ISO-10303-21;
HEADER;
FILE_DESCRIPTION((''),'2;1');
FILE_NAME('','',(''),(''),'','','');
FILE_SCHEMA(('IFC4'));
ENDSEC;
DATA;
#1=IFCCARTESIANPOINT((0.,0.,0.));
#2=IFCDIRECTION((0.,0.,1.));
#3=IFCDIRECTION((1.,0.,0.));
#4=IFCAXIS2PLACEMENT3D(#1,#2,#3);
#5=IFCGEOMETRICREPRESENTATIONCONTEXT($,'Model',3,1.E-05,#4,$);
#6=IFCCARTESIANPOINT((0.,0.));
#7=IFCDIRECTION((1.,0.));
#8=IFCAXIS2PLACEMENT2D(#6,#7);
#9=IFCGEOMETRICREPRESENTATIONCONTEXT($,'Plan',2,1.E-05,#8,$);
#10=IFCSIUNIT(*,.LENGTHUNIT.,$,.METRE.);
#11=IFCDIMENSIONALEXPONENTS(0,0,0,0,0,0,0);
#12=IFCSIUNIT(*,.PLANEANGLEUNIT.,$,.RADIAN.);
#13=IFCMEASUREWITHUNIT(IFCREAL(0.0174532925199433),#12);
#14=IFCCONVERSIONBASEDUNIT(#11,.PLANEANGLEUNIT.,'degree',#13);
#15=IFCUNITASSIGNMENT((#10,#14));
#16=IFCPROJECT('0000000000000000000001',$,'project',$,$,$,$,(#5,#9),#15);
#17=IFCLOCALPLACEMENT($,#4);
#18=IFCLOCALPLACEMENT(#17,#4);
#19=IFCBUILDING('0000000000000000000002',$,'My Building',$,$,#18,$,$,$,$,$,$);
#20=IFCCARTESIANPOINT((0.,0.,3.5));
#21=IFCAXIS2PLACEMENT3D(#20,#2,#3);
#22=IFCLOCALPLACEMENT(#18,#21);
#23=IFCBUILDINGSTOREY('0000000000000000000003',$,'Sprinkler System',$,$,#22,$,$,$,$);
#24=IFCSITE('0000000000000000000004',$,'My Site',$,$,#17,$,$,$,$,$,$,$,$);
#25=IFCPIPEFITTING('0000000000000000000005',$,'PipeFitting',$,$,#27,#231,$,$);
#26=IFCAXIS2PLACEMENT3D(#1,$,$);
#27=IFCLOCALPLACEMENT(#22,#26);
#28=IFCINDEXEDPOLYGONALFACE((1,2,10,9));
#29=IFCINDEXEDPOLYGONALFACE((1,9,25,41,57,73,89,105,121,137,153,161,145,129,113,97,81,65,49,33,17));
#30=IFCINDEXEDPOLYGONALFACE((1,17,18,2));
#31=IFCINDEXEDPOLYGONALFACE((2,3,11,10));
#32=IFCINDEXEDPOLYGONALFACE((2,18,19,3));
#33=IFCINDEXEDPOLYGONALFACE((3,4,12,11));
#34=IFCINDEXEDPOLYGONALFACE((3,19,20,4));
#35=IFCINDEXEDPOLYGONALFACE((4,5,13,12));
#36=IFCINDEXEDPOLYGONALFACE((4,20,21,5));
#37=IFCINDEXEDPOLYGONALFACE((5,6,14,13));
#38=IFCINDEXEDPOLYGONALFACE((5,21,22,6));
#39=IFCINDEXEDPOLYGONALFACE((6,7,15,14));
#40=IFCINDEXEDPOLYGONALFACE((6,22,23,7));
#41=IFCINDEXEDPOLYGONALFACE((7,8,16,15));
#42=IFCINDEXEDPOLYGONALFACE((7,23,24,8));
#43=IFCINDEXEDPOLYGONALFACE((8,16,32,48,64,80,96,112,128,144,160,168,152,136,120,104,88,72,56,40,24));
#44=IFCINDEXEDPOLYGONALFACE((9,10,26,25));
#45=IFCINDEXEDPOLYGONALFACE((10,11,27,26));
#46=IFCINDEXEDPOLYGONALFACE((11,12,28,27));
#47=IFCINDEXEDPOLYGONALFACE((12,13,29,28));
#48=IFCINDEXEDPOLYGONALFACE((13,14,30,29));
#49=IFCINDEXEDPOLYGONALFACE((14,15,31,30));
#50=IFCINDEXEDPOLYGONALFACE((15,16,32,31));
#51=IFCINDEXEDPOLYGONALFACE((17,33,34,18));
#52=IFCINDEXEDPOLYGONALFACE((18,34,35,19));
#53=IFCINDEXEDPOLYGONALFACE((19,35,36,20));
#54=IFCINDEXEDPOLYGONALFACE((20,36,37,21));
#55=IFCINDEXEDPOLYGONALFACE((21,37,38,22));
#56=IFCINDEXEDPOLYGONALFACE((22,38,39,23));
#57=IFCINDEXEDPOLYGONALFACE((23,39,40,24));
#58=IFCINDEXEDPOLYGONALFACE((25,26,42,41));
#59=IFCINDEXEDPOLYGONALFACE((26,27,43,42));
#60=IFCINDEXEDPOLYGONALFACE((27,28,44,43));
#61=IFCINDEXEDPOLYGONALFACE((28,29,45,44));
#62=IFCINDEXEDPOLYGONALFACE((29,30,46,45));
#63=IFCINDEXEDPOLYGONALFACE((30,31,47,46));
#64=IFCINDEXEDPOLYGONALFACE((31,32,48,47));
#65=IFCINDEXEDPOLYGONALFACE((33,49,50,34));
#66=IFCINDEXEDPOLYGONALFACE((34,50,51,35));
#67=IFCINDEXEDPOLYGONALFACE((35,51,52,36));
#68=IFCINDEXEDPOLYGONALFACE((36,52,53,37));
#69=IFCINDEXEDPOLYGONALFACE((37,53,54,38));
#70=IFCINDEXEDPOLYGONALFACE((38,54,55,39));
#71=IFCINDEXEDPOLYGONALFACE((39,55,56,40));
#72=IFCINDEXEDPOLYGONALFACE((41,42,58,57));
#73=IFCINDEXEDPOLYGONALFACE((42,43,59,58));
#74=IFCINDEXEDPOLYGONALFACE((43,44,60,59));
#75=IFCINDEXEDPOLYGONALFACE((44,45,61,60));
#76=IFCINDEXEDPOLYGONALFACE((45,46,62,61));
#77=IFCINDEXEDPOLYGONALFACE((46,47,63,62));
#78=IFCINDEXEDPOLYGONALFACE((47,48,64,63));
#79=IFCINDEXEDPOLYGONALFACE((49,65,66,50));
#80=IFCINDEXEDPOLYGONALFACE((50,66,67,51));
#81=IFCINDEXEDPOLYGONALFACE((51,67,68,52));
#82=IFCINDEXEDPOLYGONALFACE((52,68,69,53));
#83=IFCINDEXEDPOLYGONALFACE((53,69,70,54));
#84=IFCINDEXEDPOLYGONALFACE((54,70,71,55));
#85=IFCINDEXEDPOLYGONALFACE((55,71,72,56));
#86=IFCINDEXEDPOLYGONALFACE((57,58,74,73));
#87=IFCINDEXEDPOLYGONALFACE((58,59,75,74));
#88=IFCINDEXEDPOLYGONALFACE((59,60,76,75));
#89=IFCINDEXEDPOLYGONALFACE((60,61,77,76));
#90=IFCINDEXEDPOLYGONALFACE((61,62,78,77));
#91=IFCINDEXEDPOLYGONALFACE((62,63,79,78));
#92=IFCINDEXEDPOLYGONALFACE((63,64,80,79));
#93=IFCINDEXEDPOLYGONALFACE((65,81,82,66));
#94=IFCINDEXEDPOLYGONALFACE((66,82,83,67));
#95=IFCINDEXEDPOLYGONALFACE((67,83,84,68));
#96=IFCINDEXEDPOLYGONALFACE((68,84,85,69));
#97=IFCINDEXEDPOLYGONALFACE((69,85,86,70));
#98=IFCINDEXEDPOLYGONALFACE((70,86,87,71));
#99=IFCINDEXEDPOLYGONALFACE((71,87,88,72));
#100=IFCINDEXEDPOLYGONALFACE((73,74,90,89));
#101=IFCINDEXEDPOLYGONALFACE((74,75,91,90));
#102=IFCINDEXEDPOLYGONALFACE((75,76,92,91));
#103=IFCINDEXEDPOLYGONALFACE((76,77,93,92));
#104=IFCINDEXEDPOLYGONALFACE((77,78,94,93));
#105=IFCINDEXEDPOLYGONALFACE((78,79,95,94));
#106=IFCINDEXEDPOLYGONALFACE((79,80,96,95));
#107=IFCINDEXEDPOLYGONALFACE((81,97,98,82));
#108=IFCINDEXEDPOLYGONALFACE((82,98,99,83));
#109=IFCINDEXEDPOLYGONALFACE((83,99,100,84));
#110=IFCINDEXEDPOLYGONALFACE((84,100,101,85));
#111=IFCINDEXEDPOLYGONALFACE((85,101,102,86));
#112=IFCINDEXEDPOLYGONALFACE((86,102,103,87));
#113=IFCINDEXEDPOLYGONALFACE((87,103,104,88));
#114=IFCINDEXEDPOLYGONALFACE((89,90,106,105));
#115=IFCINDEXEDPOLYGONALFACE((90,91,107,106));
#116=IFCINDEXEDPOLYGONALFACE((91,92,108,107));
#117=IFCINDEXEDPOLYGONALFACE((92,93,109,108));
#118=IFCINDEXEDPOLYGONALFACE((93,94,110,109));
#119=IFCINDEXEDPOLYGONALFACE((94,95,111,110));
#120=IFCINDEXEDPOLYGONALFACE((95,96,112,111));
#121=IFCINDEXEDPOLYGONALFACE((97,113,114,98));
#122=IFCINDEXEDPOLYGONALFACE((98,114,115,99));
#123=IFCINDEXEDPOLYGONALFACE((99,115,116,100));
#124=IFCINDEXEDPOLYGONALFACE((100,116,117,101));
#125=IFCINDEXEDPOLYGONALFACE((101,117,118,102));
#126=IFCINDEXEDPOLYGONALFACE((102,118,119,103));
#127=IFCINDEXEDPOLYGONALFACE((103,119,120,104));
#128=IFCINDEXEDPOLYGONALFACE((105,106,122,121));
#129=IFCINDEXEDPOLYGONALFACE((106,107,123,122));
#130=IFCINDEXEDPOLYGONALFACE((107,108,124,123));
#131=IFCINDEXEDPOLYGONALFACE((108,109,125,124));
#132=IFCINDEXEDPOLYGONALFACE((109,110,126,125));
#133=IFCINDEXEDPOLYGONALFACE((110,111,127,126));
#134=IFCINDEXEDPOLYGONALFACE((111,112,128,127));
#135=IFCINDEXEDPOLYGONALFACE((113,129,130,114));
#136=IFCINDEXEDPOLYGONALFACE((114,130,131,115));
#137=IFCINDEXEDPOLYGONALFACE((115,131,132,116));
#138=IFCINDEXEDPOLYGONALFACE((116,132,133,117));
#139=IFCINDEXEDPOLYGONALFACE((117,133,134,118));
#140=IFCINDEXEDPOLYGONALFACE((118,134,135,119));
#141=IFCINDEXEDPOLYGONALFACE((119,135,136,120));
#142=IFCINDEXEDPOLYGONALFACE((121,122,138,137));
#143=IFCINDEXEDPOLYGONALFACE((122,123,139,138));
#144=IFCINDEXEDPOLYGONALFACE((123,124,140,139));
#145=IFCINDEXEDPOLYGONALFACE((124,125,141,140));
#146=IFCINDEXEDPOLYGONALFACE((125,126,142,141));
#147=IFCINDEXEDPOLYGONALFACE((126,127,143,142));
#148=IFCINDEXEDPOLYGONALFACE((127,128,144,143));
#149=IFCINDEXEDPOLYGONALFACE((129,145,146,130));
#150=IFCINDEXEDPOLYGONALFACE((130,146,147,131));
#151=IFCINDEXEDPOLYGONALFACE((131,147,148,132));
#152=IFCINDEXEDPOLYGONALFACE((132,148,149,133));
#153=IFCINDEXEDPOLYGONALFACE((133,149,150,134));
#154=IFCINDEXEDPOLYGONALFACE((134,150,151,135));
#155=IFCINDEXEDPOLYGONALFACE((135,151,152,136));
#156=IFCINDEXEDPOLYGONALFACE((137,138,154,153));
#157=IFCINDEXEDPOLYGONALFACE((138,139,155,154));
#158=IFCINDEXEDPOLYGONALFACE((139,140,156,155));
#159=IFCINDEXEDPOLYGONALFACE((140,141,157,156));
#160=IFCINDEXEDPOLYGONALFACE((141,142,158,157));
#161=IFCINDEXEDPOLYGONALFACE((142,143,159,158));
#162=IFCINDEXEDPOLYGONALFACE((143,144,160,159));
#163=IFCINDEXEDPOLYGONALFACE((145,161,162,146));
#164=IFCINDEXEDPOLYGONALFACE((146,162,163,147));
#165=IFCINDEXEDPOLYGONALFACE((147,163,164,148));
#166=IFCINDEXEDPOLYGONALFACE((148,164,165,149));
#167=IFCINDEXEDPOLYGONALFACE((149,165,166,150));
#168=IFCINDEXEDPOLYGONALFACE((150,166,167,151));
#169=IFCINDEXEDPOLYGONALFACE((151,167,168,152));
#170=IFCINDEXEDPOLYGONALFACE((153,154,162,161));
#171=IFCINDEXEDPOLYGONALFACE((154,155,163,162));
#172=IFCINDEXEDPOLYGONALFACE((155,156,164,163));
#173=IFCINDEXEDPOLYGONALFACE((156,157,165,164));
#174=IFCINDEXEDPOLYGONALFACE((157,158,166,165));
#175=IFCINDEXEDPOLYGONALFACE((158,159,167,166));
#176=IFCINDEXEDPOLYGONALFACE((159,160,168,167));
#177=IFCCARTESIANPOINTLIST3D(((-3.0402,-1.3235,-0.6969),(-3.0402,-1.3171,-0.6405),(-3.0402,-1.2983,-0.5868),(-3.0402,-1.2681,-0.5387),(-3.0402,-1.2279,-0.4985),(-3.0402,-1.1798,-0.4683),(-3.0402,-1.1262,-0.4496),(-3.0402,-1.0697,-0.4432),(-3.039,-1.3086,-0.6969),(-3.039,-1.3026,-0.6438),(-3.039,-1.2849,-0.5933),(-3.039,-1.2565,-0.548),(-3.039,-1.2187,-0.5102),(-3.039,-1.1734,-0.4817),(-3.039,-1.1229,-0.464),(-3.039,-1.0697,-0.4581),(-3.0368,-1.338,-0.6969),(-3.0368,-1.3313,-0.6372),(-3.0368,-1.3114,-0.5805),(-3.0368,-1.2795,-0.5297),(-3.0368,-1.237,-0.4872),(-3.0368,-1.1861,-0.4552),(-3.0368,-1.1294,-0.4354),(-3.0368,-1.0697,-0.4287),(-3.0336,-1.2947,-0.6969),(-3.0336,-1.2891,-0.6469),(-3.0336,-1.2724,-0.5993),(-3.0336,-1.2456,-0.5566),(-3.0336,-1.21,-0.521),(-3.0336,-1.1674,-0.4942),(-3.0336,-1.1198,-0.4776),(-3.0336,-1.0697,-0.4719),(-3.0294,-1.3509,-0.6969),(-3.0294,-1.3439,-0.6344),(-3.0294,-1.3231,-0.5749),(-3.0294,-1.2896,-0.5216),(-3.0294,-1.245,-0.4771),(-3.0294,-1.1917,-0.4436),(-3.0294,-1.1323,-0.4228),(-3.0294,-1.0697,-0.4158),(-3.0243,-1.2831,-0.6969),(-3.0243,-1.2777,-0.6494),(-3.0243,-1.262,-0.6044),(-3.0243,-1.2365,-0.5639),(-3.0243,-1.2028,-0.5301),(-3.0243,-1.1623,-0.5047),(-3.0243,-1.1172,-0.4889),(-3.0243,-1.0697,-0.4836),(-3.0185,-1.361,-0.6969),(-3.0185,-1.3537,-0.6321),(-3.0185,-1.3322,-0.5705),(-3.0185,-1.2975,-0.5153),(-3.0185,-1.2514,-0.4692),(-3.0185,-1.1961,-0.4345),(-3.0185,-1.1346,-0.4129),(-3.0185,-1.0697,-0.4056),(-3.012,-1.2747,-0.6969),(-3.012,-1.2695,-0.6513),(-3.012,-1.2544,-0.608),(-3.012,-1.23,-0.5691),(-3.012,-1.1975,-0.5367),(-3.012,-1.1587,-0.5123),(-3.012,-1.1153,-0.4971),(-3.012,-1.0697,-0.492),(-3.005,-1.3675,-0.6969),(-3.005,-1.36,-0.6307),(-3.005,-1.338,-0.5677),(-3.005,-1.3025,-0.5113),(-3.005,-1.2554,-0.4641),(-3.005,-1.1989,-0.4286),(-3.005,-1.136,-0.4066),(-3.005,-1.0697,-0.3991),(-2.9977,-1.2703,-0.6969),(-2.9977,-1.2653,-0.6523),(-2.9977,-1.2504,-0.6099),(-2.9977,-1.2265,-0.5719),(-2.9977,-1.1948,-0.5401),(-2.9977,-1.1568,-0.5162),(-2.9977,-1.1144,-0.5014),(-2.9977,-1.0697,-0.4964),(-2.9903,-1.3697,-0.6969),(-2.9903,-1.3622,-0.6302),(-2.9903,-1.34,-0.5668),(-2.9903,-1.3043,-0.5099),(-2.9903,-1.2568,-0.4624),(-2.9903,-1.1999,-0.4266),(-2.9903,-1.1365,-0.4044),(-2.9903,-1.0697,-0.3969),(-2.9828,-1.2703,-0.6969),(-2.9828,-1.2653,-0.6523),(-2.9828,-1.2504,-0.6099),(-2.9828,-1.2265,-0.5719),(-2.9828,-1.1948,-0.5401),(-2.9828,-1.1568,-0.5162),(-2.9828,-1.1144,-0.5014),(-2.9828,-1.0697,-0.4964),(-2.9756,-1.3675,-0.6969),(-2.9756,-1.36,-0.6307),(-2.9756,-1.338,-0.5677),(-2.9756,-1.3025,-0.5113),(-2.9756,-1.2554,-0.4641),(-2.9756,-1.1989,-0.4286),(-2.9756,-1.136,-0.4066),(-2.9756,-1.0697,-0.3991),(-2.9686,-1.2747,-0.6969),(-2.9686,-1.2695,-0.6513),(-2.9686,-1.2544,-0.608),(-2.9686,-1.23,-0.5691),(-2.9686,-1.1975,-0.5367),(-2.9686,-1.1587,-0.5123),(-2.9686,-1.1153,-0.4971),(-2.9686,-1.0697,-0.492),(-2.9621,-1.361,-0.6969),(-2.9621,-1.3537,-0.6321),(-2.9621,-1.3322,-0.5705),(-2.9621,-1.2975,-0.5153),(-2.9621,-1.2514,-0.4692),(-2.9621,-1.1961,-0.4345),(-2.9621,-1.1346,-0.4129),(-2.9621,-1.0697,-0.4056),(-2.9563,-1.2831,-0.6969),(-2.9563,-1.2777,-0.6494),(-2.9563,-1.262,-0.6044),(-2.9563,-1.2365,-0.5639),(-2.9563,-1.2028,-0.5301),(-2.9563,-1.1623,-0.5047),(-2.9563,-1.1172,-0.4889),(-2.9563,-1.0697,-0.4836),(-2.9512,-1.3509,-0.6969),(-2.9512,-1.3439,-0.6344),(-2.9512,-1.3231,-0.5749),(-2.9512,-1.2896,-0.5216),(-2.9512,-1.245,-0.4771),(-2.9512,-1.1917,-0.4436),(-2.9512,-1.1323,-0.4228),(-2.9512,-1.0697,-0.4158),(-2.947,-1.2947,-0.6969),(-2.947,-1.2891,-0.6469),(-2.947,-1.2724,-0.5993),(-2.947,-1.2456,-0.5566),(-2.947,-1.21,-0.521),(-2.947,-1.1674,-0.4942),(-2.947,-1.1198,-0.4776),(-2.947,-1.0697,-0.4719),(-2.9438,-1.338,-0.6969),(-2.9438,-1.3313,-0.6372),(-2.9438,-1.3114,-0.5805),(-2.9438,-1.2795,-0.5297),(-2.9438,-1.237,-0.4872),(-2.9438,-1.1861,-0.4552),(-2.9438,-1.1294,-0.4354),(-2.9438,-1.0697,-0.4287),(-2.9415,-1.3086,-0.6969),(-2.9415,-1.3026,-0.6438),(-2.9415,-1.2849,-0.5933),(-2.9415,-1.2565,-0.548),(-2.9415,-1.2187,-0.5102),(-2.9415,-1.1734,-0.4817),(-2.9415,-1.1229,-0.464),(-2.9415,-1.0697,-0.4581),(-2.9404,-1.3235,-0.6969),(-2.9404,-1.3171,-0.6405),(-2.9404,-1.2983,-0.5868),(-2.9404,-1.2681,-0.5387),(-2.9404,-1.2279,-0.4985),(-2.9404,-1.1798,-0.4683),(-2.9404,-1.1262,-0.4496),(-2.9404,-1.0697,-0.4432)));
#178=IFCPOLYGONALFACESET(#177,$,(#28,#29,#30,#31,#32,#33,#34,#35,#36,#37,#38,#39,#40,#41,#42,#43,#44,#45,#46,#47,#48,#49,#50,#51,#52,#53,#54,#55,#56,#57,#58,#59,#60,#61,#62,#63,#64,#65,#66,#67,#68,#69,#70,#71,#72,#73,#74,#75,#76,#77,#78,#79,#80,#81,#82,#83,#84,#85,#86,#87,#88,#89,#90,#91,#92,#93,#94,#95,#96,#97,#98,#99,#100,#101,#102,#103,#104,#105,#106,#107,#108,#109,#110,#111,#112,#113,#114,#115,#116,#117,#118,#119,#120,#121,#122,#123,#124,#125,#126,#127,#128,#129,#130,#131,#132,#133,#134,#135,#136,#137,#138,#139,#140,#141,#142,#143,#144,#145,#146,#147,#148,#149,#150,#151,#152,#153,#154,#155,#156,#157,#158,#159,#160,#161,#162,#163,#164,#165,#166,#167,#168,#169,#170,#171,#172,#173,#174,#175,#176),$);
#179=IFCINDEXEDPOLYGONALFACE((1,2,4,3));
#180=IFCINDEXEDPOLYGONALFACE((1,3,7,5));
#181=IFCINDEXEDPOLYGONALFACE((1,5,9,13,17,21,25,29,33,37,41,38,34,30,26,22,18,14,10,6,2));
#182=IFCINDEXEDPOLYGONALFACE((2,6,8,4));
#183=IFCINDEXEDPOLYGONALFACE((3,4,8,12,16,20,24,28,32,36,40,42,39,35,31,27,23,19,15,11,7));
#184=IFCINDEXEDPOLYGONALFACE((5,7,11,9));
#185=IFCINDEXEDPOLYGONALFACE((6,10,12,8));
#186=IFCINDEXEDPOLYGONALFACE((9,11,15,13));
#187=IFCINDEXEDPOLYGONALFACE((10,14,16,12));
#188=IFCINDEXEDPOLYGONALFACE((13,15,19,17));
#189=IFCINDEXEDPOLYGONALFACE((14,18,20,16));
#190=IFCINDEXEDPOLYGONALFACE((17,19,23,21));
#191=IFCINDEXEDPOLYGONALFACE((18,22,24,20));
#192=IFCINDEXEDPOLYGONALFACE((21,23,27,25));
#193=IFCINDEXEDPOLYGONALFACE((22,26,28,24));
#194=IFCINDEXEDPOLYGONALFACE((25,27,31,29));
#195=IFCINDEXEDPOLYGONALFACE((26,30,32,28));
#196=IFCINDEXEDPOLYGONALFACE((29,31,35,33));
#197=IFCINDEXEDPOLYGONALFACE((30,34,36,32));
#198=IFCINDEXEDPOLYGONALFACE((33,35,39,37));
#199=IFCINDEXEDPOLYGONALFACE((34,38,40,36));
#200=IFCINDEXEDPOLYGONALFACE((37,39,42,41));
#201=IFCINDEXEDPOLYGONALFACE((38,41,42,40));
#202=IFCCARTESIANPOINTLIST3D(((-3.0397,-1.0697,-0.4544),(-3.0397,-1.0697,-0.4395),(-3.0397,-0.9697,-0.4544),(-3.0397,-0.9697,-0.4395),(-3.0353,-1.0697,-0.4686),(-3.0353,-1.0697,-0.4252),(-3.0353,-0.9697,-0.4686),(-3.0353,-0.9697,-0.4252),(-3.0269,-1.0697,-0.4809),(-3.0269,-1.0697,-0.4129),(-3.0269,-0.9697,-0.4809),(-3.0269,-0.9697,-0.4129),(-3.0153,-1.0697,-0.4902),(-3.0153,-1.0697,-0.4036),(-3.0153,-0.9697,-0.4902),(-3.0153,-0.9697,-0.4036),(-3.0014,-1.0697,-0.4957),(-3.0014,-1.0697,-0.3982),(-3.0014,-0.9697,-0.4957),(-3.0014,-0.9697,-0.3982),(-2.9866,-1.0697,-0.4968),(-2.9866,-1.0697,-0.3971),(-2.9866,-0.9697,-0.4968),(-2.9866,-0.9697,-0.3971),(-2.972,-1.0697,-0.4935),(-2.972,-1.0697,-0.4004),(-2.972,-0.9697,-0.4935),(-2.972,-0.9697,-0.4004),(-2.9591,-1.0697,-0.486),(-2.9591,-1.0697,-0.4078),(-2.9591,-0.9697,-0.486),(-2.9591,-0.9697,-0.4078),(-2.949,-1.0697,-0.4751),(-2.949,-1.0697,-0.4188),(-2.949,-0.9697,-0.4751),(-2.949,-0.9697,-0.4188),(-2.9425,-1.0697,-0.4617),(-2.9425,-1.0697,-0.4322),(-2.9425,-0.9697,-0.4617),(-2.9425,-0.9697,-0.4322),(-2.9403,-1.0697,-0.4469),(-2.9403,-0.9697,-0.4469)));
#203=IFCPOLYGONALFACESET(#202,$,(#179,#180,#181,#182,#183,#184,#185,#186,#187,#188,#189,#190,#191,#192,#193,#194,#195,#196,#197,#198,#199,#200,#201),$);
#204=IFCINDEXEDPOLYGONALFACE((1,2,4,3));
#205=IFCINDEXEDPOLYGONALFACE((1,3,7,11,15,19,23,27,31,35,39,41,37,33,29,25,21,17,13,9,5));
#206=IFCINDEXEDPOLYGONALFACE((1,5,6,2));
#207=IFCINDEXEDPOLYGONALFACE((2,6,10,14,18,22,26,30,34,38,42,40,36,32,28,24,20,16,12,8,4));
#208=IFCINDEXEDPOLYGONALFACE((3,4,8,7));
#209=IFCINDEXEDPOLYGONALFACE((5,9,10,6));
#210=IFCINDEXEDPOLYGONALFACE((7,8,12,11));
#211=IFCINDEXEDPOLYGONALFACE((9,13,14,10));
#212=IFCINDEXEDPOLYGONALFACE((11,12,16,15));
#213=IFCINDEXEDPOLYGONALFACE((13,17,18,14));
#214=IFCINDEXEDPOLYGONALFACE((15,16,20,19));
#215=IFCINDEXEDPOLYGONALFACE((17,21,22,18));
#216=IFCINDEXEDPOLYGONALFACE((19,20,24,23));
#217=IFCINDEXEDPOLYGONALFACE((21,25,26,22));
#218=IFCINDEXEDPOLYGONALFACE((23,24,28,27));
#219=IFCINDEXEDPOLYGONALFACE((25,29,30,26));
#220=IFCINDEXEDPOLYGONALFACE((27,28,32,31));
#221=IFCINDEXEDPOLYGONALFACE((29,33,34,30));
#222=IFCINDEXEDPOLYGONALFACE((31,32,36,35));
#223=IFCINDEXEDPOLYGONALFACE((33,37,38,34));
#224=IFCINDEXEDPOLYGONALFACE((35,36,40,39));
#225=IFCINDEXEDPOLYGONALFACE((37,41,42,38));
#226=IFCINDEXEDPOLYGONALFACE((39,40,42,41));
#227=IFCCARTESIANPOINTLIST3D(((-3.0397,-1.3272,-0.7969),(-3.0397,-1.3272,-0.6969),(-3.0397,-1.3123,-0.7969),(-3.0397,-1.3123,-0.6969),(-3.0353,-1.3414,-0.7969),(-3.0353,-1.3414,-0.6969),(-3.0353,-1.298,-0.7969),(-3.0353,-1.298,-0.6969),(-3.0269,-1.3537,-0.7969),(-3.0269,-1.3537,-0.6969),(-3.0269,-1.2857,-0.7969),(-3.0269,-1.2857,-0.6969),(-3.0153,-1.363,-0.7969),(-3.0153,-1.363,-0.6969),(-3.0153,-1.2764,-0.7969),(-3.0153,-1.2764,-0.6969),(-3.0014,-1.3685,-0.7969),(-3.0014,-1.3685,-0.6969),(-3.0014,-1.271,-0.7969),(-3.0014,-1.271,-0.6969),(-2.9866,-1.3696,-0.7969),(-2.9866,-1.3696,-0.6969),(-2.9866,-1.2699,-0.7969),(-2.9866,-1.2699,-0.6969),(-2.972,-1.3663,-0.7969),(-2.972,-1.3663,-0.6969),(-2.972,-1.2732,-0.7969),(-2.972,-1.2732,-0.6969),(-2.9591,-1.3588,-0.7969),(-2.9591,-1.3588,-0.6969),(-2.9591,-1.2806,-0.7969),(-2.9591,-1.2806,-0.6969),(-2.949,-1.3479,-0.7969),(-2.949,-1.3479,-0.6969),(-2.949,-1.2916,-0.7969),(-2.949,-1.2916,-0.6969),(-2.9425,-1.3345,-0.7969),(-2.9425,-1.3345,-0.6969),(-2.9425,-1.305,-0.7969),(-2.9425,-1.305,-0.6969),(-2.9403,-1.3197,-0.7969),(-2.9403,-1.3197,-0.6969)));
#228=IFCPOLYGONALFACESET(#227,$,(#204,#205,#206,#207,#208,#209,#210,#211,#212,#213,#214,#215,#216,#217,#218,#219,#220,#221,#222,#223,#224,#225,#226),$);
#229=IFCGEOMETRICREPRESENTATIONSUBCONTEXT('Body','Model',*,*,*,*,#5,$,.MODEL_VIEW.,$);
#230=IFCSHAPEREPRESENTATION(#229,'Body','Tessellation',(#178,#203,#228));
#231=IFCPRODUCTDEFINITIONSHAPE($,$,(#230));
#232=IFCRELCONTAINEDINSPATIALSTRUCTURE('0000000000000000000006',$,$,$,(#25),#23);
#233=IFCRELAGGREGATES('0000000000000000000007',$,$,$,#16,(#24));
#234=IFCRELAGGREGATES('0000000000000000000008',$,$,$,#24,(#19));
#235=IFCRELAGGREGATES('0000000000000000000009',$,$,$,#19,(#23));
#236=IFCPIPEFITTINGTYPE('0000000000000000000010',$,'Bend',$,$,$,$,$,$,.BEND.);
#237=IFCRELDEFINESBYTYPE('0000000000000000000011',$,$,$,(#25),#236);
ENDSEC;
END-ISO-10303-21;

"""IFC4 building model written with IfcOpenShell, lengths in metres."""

from ifc_helpers import new_model, entity, si_unit, converted_unit, frame, origin_with_axes, origin_2d_with_axis, place, context, subcontext, project, spatial, circle, extrude, source, transform, mapped, type_object, type_shapes, element, save


model = new_model("IFC4")

# Units and contexts
model_context = context("Model", 3, precision=1e-05, world=origin_with_axes())
plan_context = context("Plan", 2, precision=1e-05, world=origin_2d_with_axis())
body_context = subcontext(model_context, "Body", "Model", "MODEL_VIEW")
ifc_project = project(units=[si_unit("LENGTHUNIT", "METRE"), converted_unit("PLANEANGLEUNIT", "degree", entity("IfcReal", 0.0174532925199433), si_unit("PLANEANGLEUNIT", "RADIAN"), dimensions=[0, 0, 0, 0, 0, 0, 0])], contexts=[model_context, plan_context])

# Site, building, storey
site_placement = place(None, origin_with_axes())
site = spatial("IfcSite", under=ifc_project, at=site_placement, Name="My Site")
building_placement = place(site_placement, origin_with_axes())
building = spatial("IfcBuilding", under=site, at=building_placement, Name="My Building")
storey_placement = place(building_placement, frame((0.0, 0.0, 3.5), z_axis=(0.0, 0.0, 1.0), x_axis=(1.0, 0.0, 0.0)))
storey = spatial("IfcBuildingStorey", under=building, at=storey_placement, Name="Sprinkler System")

# Pipe fitting
pipe_fitting_type_1 = type_object("IfcPipeFittingType", Name="Bend", PredefinedType="BEND")
shared_shape_1 = source(origin_with_axes(), body_context, "Body", "SolidModel", [
    entity("IfcSweptDiskSolid", entity("IfcIndexedPolyCurve", entity("IfcCartesianPointList3D", [[0.0, 0.0, 0.1], [0.0, -0.0732, 0.2768], [0.0, -0.25, 0.35]]), [entity("IfcArcIndex", [1, 2, 3])]), 0.05),
    extrude(circle(Radius=0.05), origin_with_axes(), (0.0, 0.0, 1.0), 0.1),
    extrude(circle(Radius=0.05), frame((0.0, -0.25, 0.35), z_axis=(0.0, -1.0, 0.000044), x_axis=(1.0, 0.0, 0.0)), (0.0, 0.0, 1.0), 0.1),
])
type_shapes(pipe_fitting_type_1, [shared_shape_1])
for number, where, z_axis, x_axis, name in (
    (1, (-2.9903, -0.9697, -0.4469), (0.0, -1.0, -0.00001), (1.0, 0.0, 0.0), "PipeFitting"),
):
    element("IfcPipeFitting", number, at=place(storey_placement, frame(where, z_axis=z_axis, x_axis=x_axis)), inside=storey, type_object=pipe_fitting_type_1, Name=name, context=body_context, shape_type="MappedRepresentation", body=[
        mapped(shared_shape_1, transform((0.0, 0.0, 0.0), x_axis=(1.0, 0.0, 0.0), y_axis=(0.0, 1.0, 0.0), z_axis=(0.0, 0.0, 1.0), scale=1.0)),
    ])

save(model, "model.ifc")
